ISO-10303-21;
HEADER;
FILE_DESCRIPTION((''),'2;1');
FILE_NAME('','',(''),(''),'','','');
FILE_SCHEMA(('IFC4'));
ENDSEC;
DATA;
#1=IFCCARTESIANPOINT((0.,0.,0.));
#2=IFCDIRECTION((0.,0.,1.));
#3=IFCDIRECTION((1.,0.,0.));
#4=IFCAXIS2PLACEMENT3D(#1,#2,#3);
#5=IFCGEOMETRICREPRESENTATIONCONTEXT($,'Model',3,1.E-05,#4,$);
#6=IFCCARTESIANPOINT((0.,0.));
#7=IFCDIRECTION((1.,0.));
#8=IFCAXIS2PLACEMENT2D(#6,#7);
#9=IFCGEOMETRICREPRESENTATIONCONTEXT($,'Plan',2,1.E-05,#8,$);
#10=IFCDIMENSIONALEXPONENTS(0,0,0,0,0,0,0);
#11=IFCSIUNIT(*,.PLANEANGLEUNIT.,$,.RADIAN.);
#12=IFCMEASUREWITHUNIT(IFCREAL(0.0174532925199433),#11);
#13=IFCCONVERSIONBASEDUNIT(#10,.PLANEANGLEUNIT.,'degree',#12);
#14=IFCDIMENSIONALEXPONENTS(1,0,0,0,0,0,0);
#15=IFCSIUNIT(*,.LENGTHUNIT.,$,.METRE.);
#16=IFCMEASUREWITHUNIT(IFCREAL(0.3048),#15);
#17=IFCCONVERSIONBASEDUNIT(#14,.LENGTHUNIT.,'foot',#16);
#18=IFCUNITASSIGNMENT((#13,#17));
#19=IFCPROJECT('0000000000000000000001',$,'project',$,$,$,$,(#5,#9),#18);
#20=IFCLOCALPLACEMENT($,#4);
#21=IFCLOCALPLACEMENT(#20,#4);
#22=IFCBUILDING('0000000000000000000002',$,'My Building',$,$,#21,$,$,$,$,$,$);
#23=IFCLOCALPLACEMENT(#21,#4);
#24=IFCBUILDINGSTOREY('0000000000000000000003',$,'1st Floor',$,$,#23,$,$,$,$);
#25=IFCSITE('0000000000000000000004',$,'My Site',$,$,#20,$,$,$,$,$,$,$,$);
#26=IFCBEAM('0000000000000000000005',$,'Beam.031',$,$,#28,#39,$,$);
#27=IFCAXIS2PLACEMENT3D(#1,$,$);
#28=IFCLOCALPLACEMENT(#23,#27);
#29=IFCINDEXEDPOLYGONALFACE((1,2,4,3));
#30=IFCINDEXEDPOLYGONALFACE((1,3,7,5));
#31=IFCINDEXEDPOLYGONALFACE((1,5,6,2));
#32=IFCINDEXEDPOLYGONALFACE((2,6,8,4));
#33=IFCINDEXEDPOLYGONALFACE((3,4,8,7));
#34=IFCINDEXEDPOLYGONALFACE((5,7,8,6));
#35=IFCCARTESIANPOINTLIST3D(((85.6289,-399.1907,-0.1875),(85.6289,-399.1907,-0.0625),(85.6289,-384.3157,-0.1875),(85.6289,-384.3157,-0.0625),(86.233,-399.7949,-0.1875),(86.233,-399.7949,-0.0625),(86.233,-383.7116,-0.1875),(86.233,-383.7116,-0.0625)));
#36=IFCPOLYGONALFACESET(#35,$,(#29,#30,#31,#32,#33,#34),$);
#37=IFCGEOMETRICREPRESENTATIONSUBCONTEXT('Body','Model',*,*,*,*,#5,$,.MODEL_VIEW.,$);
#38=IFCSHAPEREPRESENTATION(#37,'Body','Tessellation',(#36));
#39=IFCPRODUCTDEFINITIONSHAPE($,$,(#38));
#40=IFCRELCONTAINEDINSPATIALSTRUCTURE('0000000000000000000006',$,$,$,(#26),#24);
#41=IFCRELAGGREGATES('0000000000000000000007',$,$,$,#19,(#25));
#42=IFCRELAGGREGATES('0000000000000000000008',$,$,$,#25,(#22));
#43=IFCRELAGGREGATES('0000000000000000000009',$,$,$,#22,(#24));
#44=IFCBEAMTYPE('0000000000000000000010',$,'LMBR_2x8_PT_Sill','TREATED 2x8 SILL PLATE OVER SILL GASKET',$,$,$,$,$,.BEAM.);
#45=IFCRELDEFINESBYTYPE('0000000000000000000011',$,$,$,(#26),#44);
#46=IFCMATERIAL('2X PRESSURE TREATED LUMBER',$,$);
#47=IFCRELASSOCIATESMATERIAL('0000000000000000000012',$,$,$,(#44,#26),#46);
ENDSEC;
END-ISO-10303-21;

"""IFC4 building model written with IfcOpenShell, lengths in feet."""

from ifc_helpers import new_model, entity, si_unit, converted_unit, frame, origin_with_axes, origin_2d_with_axis, place, context, subcontext, project, spatial, rectangle, extrude, clip, halfspace, material, material_profile, profile_set, profile_usage, type_object, element, save


model = new_model("IFC4")

# Units and contexts
model_context = context("Model", 3, precision=1e-05, world=origin_with_axes())
plan_context = context("Plan", 2, precision=1e-05, world=origin_2d_with_axis())
body_context = subcontext(model_context, "Body", "Model", "MODEL_VIEW")
ifc_project = project(units=[converted_unit("PLANEANGLEUNIT", "degree", entity("IfcReal", 0.0174532925199433), si_unit("PLANEANGLEUNIT", "RADIAN"), dimensions=[0, 0, 0, 0, 0, 0, 0]), converted_unit("LENGTHUNIT", "foot", entity("IfcReal", 0.3048), si_unit("LENGTHUNIT", "METRE"), dimensions=[1, 0, 0, 0, 0, 0, 0])], contexts=[model_context, plan_context])

# Site, building, storey
site_placement = place(None, origin_with_axes())
site = spatial("IfcSite", under=ifc_project, at=site_placement, Name="My Site")
building_placement = place(site_placement, origin_with_axes())
building = spatial("IfcBuilding", under=site, at=building_placement, Name="My Building")
storey_placement = place(building_placement, origin_with_axes())
storey = spatial("IfcBuildingStorey", under=building, at=storey_placement, Name="1st Floor")

# Shared definitions
ifc_material_1 = material(Name="2X PRESSURE TREATED LUMBER")

# Beam
ifc_material_profile_1 = material_profile(ifc_material_1, rectangle(XDim=0.125, YDim=0.6042, kind="CURVE"))
ifc_profile_set_1 = profile_set([ifc_material_profile_1])
ifc_profile_usage_1 = profile_usage(ifc_profile_set_1)
beam_type_1 = type_object("IfcBeamType", Name="LMBR_2x8_PT_Sill", Description="TREATED 2x8 SILL PLATE OVER SILL GASKET", PredefinedType="BEAM", material=ifc_profile_set_1)
beam_1_placement = place(storey_placement, frame((85.9309, -399.7949, -0.125), z_axis=(0.0, 1.0, 0.0), x_axis=(0.0, 0.0, 1.0)))
element("IfcBeam", 1, at=beam_1_placement, inside=storey, type_object=beam_type_1, material=ifc_profile_usage_1, Name="Beam.031", context=body_context, shape_type="Clipping", body=[
    clip(clip(extrude(rectangle(XDim=0.125, YDim=0.6042, kind="CURVE"), origin_with_axes(), (0.0, 0.0, 1.0), 16.0833), halfspace(frame((0.125, 0.3021, 0.0), z_axis=(0.0, -0.707092, -0.707121), x_axis=(-1.0, 0.0, 0.0)), False)), halfspace(frame((0.125, 0.3021, 16.0833), z_axis=(0.0, -0.707092, 0.707121), x_axis=(-1.0, 0.0, 0.0)), False)),
])

save(model, "model.ifc")
